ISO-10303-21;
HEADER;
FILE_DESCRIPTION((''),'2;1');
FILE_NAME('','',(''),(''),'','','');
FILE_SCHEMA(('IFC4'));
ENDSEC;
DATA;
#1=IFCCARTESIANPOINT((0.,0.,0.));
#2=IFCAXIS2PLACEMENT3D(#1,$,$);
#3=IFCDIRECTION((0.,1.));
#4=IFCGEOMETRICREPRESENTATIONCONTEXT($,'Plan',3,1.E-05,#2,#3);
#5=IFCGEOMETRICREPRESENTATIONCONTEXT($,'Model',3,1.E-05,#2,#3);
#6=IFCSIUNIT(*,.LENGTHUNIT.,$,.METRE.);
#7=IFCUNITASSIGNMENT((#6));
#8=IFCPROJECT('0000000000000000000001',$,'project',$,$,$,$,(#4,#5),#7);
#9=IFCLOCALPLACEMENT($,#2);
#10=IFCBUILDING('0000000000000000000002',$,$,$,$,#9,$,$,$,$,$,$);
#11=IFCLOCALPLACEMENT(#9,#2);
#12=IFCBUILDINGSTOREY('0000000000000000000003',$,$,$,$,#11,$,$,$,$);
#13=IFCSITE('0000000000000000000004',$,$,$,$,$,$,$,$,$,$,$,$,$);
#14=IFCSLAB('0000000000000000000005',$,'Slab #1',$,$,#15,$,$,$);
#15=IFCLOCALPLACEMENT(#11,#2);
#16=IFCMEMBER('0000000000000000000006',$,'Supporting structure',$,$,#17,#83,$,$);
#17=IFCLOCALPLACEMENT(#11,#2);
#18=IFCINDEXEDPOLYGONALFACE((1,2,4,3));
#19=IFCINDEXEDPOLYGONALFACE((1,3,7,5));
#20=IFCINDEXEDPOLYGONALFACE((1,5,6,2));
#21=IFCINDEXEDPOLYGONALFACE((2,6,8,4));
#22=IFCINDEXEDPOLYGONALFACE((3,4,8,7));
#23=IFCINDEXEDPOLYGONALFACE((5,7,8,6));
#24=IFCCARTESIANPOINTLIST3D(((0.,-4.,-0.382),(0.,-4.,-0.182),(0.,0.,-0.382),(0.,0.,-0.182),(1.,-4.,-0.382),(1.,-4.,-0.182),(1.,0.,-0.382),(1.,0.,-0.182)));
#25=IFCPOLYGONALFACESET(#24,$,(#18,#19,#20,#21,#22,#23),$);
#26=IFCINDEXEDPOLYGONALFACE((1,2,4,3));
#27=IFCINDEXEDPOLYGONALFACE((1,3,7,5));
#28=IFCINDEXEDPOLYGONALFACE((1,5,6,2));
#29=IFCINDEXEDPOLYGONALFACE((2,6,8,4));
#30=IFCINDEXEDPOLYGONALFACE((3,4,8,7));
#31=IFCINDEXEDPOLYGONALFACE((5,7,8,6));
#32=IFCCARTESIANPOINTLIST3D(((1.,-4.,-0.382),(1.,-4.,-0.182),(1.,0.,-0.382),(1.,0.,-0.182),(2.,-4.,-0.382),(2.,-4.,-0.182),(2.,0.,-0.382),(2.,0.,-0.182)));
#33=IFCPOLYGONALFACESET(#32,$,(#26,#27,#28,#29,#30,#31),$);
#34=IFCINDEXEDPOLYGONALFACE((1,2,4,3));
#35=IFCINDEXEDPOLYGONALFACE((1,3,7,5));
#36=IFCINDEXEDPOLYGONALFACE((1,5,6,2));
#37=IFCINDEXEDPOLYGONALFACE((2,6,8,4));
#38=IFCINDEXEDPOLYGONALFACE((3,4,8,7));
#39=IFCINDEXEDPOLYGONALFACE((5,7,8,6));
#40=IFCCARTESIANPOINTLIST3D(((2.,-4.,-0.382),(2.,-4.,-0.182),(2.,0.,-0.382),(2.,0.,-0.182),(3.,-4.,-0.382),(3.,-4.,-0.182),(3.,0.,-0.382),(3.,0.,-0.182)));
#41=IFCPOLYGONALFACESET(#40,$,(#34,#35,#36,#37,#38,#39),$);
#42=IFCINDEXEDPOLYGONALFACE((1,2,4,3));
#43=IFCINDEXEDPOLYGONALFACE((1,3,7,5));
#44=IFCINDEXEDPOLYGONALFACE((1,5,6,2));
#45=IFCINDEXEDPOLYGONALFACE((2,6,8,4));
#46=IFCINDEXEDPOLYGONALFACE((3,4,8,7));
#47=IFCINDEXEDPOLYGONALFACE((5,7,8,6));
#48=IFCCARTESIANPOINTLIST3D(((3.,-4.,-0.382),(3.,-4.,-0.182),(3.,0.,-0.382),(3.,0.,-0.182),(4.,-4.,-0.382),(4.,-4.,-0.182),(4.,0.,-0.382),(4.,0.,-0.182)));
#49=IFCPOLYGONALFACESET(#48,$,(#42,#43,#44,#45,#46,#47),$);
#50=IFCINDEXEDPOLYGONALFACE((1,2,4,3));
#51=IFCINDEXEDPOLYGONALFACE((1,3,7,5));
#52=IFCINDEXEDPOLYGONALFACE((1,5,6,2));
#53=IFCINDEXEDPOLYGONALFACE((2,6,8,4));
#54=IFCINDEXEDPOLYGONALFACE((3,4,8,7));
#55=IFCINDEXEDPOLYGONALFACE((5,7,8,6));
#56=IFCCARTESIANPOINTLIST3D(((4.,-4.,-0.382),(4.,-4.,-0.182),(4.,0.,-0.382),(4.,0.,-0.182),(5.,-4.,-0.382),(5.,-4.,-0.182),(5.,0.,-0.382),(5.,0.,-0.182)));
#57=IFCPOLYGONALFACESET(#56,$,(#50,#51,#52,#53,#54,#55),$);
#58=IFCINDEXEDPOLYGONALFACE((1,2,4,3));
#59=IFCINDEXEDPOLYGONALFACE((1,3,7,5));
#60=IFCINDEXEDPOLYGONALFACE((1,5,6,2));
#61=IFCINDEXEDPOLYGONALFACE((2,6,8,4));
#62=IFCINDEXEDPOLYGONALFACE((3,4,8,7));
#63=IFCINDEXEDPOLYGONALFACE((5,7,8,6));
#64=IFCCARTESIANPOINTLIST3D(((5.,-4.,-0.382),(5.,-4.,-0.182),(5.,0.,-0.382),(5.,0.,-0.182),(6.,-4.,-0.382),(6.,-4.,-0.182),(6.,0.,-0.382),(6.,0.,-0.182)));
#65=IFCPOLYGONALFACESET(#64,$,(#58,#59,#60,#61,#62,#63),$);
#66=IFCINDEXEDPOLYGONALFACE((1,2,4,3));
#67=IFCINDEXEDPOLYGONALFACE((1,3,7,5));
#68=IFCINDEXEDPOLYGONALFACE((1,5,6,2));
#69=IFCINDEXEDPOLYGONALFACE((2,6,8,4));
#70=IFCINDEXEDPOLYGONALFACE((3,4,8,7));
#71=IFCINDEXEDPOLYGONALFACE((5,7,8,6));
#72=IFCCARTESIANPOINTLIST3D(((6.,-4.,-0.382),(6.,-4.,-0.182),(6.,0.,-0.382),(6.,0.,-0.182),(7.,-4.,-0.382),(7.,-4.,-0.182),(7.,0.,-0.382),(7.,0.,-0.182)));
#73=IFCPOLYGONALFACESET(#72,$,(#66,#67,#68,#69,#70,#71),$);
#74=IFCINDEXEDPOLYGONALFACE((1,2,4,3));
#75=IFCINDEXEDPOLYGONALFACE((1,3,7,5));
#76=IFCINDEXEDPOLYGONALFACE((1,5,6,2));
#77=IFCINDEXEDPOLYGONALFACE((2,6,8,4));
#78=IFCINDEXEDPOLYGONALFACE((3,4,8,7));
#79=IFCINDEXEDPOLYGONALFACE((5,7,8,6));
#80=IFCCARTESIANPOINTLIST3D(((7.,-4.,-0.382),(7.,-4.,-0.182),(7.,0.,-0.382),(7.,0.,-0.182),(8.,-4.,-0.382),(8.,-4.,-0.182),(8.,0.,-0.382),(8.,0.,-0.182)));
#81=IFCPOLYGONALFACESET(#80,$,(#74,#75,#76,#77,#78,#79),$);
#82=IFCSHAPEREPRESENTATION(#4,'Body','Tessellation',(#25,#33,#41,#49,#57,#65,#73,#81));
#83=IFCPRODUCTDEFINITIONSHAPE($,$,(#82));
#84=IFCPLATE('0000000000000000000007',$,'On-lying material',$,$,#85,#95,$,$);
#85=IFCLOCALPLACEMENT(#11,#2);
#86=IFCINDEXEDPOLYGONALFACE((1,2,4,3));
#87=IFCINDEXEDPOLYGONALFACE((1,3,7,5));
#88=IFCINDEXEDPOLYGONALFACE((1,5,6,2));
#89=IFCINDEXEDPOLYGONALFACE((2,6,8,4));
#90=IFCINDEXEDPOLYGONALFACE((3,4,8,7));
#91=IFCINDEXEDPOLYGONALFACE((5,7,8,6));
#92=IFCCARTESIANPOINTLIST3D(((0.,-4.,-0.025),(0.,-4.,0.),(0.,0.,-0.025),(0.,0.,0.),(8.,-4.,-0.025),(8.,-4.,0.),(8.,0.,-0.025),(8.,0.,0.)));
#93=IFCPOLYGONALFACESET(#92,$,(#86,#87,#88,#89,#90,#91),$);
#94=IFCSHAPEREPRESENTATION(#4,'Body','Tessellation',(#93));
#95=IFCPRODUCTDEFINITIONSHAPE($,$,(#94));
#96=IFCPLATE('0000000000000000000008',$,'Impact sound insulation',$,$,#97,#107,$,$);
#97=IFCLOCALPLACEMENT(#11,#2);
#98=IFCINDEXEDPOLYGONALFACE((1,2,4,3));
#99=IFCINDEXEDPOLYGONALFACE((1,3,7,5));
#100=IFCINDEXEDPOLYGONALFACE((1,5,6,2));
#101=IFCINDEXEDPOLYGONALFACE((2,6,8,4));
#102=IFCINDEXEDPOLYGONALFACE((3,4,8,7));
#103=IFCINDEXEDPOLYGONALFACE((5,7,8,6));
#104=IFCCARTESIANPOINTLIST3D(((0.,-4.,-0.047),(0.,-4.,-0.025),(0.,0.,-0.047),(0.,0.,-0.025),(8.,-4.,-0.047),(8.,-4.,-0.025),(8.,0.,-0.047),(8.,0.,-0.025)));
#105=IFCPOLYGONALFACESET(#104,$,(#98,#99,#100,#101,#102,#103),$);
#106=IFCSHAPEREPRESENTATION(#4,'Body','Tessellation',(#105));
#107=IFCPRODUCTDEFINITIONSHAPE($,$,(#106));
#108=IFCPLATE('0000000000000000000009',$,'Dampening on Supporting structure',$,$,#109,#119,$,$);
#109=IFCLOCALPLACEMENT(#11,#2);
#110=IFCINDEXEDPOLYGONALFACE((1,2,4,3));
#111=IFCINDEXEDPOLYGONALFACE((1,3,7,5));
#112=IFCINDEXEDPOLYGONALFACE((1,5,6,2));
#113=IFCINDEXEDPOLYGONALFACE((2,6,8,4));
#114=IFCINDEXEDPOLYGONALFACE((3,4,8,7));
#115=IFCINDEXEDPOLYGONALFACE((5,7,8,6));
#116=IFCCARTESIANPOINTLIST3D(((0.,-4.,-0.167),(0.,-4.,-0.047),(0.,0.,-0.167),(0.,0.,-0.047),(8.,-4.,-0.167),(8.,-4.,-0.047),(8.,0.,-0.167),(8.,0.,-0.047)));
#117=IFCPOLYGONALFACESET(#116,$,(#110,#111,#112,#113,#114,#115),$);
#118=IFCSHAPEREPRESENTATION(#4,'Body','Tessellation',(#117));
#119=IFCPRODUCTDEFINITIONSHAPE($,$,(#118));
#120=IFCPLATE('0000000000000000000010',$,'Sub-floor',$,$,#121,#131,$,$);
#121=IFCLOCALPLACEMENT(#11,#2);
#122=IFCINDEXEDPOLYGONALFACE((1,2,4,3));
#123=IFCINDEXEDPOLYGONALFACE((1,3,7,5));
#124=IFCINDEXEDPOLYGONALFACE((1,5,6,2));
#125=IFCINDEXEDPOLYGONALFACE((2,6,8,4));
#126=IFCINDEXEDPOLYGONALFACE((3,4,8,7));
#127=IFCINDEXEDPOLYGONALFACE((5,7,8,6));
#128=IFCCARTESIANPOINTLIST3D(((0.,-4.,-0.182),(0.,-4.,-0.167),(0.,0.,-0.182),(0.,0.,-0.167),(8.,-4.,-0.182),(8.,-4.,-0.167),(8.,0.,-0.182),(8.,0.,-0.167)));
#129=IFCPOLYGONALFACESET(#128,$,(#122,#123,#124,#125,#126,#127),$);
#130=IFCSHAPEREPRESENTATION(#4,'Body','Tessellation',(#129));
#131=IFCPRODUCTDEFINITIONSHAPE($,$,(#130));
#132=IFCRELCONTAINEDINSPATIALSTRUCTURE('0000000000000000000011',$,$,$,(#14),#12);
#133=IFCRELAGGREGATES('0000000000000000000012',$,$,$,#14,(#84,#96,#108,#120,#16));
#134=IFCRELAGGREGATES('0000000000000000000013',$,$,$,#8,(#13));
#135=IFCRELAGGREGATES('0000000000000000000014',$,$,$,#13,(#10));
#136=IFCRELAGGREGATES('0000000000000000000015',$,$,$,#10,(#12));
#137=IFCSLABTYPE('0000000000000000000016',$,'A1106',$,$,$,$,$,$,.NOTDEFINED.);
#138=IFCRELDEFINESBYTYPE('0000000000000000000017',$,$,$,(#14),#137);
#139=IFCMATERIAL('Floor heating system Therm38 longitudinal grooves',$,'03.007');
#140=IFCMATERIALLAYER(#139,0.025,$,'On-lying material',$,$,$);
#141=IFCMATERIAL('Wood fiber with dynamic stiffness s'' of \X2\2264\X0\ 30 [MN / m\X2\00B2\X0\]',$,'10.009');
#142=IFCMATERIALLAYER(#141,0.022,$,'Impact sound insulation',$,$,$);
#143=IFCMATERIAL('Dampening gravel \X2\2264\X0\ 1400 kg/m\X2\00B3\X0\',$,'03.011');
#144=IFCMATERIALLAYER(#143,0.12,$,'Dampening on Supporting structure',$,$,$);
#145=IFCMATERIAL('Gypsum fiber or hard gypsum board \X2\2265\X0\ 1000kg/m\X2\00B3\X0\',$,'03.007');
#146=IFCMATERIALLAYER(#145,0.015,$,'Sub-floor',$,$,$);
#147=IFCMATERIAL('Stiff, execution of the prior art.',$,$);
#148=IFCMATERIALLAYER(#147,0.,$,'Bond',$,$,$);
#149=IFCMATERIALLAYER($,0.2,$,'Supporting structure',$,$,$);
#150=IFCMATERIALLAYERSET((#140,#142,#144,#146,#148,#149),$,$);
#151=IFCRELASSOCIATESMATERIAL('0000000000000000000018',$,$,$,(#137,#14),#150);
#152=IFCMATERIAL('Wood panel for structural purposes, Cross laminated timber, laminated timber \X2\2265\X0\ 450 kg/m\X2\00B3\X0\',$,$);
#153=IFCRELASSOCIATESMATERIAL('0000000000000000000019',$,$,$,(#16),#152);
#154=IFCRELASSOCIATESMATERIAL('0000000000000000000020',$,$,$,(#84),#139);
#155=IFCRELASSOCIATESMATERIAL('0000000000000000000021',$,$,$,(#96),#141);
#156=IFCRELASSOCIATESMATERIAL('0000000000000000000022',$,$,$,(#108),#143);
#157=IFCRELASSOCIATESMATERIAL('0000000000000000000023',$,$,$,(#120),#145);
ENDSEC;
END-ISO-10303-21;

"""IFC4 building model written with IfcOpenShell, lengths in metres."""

from ifc_helpers import new_model, si_unit, direction, frame, frame_2d, origin, origin_with_axes, place, context, project, spatial, rectangle, extrude, material, layer, layer_set, type_object, element, aggregate, save


model = new_model("IFC4")

# Units and contexts
plan_context = context("Plan", 3, precision=1e-05, world=origin(), true_north=direction((0.0, 1.0)))
model_context = context("Model", 3, precision=1e-05, world=origin(), true_north=direction((0.0, 1.0)))
ifc_project = project(units=[si_unit("LENGTHUNIT", "METRE")], contexts=[plan_context, model_context])

# Site, building, storey
site = spatial("IfcSite", under=ifc_project)
building_placement = place(None, origin())
building = spatial("IfcBuilding", under=site, at=building_placement)
storey_placement = place(building_placement, origin())
storey = spatial("IfcBuildingStorey", under=building, at=storey_placement)

# Slab, member, plates
ifc_material_1 = material(Name="Floor heating system Therm38 longitudinal grooves", Category="03.007")
ifc_layer_1 = layer(ifc_material_1, 0.025, Name="On-lying material")
ifc_material_2 = material(Name="Wood fiber with dynamic stiffness s' of ≤ 30 [MN / m²]", Category="10.009")
ifc_layer_2 = layer(ifc_material_2, 0.022, Name="Impact sound insulation")
ifc_material_3 = material(Name="Dampening gravel ≤ 1400 kg/m³", Category="03.011")
ifc_layer_3 = layer(ifc_material_3, 0.12, Name="Dampening on Supporting structure")
ifc_material_4 = material(Name="Gypsum fiber or hard gypsum board ≥ 1000kg/m³", Category="03.007")
ifc_layer_4 = layer(ifc_material_4, 0.015, Name="Sub-floor")
ifc_material_5 = material(Name="Stiff, execution of the prior art.")
ifc_layer_5 = layer(ifc_material_5, 0.0, Name="Bond")
ifc_layer_6 = layer(None, 0.2, Name="Supporting structure")
ifc_layer_set = layer_set([ifc_layer_1, ifc_layer_2, ifc_layer_3, ifc_layer_4, ifc_layer_5, ifc_layer_6])
slab_type = type_object("IfcSlabType", Name="A1106", PredefinedType="NOTDEFINED", material=ifc_layer_set)
slab_placement = place(None, frame((0.0, 0.0, 0.0), z_axis=(0.0, 0.0, -1.0), x_axis=(1.0, 0.0, 0.0)))
slab = element("IfcSlab", 1, at=slab_placement, inside=storey, type_object=slab_type, material=ifc_layer_set, Name="Slab #1")
ifc_material_6 = material(Name="Wood panel for structural purposes, Cross laminated timber, laminated timber ≥ 450 kg/m³")
member_placement = place(slab_placement, origin())
member = element("IfcMember", 2, at=member_placement, material=ifc_material_6, Name="Supporting structure", context=plan_context, shape_type="SweptSolid", body=[
    extrude(rectangle(XDim=1.0, YDim=0.2, at=frame_2d((0.5, 0.1), x_axis=(1.0, 0.0))), frame((0.0, 4.0, 0.182), z_axis=(0.0, -1.0, 0.0), x_axis=(1.0, 0.0, 0.0)), (0.0, 0.0, 1.0), 4.0),
    extrude(rectangle(XDim=1.0, YDim=0.2, at=frame_2d((0.5, 0.1), x_axis=(1.0, 0.0))), frame((1.0, 4.0, 0.182), z_axis=(0.0, -1.0, 0.0), x_axis=(1.0, 0.0, 0.0)), (0.0, 0.0, 1.0), 4.0),
    extrude(rectangle(XDim=1.0, YDim=0.2, at=frame_2d((0.5, 0.1), x_axis=(1.0, 0.0))), frame((2.0, 4.0, 0.182), z_axis=(0.0, -1.0, 0.0), x_axis=(1.0, 0.0, 0.0)), (0.0, 0.0, 1.0), 4.0),
    extrude(rectangle(XDim=1.0, YDim=0.2, at=frame_2d((0.5, 0.1), x_axis=(1.0, 0.0))), frame((3.0, 4.0, 0.182), z_axis=(0.0, -1.0, 0.0), x_axis=(1.0, 0.0, 0.0)), (0.0, 0.0, 1.0), 4.0),
    extrude(rectangle(XDim=1.0, YDim=0.2, at=frame_2d((0.5, 0.1), x_axis=(1.0, 0.0))), frame((4.0, 4.0, 0.182), z_axis=(0.0, -1.0, 0.0), x_axis=(1.0, 0.0, 0.0)), (0.0, 0.0, 1.0), 4.0),
    extrude(rectangle(XDim=1.0, YDim=0.2, at=frame_2d((0.5, 0.1), x_axis=(1.0, 0.0))), frame((5.0, 4.0, 0.182), z_axis=(0.0, -1.0, 0.0), x_axis=(1.0, 0.0, 0.0)), (0.0, 0.0, 1.0), 4.0),
    extrude(rectangle(XDim=1.0, YDim=0.2, at=frame_2d((0.5, 0.1), x_axis=(1.0, 0.0))), frame((6.0, 4.0, 0.182), z_axis=(0.0, -1.0, 0.0), x_axis=(1.0, 0.0, 0.0)), (0.0, 0.0, 1.0), 4.0),
    extrude(rectangle(XDim=1.0, YDim=0.2, at=frame_2d((0.5, 0.1), x_axis=(1.0, 0.0))), frame((7.0, 4.0, 0.182), z_axis=(0.0, -1.0, 0.0), x_axis=(1.0, 0.0, 0.0)), (0.0, 0.0, 1.0), 4.0),
])
plate_1_placement = place(slab_placement, origin())
plate_1 = element("IfcPlate", 3, at=plate_1_placement, material=ifc_material_1, Name="On-lying material", context=plan_context, shape_type="SweptSolid", body=[
    extrude(rectangle(XDim=8.0, YDim=4.0, at=frame_2d((4.0, 2.0), x_axis=(1.0, 0.0))), origin_with_axes(), (0.0, 0.0, 1.0), 0.025),
])
plate_2_placement = place(slab_placement, origin())
plate_2 = element("IfcPlate", 4, at=plate_2_placement, material=ifc_material_2, Name="Impact sound insulation", context=plan_context, shape_type="SweptSolid", body=[
    extrude(rectangle(XDim=8.0, YDim=4.0, at=frame_2d((4.0, 2.0), x_axis=(1.0, 0.0))), frame((0.0, 0.0, 0.025), z_axis=(0.0, 0.0, 1.0), x_axis=(1.0, 0.0, 0.0)), (0.0, 0.0, 1.0), 0.022),
])
plate_3_placement = place(slab_placement, origin())
plate_3 = element("IfcPlate", 5, at=plate_3_placement, material=ifc_material_3, Name="Dampening on Supporting structure", context=plan_context, shape_type="SweptSolid", body=[
    extrude(rectangle(XDim=8.0, YDim=4.0, at=frame_2d((4.0, 2.0), x_axis=(1.0, 0.0))), frame((0.0, 0.0, 0.047), z_axis=(0.0, 0.0, 1.0), x_axis=(1.0, 0.0, 0.0)), (0.0, 0.0, 1.0), 0.12),
])
plate_4_placement = place(slab_placement, origin())
plate_4 = element("IfcPlate", 6, at=plate_4_placement, material=ifc_material_4, Name="Sub-floor", context=plan_context, shape_type="SweptSolid", body=[
    extrude(rectangle(XDim=8.0, YDim=4.0, at=frame_2d((4.0, 2.0), x_axis=(1.0, 0.0))), frame((0.0, 0.0, 0.167), z_axis=(0.0, 0.0, 1.0), x_axis=(1.0, 0.0, 0.0)), (0.0, 0.0, 1.0), 0.015),
])
aggregate(slab, [plate_1, plate_2, plate_3, plate_4, member])

save(model, "model.ifc")
